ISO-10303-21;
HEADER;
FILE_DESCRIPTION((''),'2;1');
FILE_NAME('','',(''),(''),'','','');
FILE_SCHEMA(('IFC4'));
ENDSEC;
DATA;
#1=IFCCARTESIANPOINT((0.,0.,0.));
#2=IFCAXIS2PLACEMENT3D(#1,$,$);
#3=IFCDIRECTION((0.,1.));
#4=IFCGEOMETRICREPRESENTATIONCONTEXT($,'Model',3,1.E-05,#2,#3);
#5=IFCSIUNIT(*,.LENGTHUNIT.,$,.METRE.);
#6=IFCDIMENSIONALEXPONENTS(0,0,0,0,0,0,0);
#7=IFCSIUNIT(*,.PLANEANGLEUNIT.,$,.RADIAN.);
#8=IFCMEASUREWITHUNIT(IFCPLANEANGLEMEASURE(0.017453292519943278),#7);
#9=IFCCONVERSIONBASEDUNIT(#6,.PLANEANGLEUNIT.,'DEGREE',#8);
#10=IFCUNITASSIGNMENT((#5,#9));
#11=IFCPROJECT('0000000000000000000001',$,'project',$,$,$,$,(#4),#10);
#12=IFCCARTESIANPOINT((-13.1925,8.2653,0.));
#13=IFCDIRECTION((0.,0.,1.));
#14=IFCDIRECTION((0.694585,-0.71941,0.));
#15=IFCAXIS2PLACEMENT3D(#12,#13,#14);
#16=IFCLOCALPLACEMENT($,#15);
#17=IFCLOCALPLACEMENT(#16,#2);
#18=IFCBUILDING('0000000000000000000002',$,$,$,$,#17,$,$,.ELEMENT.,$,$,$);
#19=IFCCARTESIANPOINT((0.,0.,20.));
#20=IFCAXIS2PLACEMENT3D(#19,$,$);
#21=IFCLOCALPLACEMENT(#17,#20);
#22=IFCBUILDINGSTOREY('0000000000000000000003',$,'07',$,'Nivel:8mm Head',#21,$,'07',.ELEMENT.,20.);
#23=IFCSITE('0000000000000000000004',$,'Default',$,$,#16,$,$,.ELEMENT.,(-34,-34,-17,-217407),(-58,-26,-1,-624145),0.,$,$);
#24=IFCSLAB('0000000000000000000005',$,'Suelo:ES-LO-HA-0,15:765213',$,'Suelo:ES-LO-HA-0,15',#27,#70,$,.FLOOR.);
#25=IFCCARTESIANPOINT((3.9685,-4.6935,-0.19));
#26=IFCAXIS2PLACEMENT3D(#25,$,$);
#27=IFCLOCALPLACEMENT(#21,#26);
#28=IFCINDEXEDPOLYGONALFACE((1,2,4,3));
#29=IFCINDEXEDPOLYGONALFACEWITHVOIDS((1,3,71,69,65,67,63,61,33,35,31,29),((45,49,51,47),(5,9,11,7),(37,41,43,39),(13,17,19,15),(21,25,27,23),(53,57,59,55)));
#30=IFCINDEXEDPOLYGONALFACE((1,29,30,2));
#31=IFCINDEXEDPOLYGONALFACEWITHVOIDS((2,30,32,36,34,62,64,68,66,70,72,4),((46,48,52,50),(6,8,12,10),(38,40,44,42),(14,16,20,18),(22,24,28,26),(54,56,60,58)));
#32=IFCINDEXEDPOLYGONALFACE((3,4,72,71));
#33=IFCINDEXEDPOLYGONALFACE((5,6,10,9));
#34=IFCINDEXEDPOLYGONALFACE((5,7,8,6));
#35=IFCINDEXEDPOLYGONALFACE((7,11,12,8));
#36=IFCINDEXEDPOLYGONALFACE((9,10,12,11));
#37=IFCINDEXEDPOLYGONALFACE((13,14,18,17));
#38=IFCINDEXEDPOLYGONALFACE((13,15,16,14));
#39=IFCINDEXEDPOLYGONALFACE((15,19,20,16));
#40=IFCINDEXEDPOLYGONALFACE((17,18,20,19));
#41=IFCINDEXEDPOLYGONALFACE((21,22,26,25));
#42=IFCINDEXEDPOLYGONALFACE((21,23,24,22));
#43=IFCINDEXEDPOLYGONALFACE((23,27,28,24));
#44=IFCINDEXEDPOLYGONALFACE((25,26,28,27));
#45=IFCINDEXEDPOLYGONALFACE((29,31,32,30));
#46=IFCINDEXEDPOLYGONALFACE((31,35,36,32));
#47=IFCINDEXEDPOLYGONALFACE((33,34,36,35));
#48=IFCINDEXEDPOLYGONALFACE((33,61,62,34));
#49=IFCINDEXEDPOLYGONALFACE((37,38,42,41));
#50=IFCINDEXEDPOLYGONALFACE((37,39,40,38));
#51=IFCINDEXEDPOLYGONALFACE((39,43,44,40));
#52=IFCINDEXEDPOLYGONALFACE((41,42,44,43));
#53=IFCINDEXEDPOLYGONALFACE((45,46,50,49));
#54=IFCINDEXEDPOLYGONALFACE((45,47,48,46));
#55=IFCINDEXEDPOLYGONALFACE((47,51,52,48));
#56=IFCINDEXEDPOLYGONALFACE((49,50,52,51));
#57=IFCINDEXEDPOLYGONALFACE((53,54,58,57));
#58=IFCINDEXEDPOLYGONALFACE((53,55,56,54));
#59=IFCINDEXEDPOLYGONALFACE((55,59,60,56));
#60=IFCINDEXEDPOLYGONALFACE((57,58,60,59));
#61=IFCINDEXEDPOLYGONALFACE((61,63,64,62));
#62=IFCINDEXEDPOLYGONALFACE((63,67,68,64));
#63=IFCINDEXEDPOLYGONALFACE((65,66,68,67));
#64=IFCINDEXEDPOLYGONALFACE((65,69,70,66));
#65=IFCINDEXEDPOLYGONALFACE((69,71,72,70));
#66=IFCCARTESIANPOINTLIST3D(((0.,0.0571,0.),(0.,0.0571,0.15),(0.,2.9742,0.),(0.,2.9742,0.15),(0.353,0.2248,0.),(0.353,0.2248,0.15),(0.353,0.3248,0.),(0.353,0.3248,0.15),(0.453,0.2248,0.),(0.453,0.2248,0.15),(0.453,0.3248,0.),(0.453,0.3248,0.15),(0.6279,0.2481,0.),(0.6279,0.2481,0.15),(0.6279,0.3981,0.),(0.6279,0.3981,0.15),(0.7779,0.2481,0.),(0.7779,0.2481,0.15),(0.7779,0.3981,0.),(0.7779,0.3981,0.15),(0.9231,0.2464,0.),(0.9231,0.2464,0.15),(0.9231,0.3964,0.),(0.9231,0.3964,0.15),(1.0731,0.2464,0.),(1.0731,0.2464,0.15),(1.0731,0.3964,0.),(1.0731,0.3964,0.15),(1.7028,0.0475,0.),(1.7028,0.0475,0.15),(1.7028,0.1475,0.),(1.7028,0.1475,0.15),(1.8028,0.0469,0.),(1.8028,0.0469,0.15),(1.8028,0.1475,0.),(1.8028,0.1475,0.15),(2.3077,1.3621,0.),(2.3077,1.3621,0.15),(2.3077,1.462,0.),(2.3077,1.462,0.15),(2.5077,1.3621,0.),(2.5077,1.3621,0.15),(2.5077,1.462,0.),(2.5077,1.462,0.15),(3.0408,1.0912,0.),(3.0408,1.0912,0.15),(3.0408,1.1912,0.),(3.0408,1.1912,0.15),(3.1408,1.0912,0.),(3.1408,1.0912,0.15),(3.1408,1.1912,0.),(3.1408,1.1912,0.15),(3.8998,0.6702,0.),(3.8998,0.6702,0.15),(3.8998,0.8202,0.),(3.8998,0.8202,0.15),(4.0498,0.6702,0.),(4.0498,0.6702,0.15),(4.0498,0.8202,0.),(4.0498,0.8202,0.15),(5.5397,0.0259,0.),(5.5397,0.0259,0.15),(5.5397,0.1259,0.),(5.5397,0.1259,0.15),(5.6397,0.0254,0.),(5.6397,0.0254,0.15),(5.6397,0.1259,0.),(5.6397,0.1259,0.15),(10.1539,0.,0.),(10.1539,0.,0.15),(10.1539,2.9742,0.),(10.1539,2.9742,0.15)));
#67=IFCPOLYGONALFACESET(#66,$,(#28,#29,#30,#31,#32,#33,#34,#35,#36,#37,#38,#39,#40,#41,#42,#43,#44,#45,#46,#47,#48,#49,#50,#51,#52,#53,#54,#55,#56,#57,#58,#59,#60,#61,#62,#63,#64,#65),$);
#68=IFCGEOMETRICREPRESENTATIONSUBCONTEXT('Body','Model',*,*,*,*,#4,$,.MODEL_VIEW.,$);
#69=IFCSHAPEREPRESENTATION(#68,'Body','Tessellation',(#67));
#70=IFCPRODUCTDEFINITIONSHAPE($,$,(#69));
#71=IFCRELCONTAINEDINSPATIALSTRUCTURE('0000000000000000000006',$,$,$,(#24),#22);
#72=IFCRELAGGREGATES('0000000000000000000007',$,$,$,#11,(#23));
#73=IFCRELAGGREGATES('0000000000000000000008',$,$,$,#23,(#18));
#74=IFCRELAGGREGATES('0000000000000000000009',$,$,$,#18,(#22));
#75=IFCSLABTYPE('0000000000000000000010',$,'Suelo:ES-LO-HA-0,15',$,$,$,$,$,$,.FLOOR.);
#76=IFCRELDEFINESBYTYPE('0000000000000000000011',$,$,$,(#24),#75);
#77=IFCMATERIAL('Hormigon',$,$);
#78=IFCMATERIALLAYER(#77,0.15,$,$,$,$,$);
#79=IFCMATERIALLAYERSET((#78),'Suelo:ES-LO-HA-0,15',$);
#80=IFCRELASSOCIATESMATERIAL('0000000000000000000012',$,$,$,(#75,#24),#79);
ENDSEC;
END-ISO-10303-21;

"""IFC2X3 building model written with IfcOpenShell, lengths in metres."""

from ifc_helpers import new_model, entity, si_unit, converted_unit, direction, frame, frame_2d, origin, origin_2d_with_axis, place, context, subcontext, project, spatial, polyline, rectangle, outline, extrude, material, layer, layer_set, layer_usage, type_object, element, save


model = new_model("IFC2X3")

# Units and contexts
model_context = context("Model", 3, precision=1e-05, world=origin(), true_north=direction((0.0, 1.0)))
body_context = subcontext(model_context, "Body", "Model", "MODEL_VIEW")
ifc_project = project(units=[si_unit("LENGTHUNIT", "METRE"), converted_unit("PLANEANGLEUNIT", "DEGREE", entity("IfcPlaneAngleMeasure", 0.017453292519943278), si_unit("PLANEANGLEUNIT", "RADIAN"), dimensions=[0, 0, 0, 0, 0, 0, 0])], contexts=[model_context])

# Site, building, storey
site_placement = place(None, frame((-13.1925, 8.2653, 0.0), z_axis=(0.0, 0.0, 1.0), x_axis=(0.694585, -0.71941, 0.0)))
site = spatial("IfcSite", under=ifc_project, at=site_placement, Name="Default", CompositionType="ELEMENT", RefLatitude=(-34, -34, -17, -217407), RefLongitude=(-58, -26, -1, -624145), RefElevation=0.0)
building_placement = place(site_placement, origin())
building = spatial("IfcBuilding", under=site, at=building_placement, CompositionType="ELEMENT")
storey_placement = place(building_placement, frame((0.0, 0.0, 20.0)))
storey = spatial("IfcBuildingStorey", under=building, at=storey_placement, Name="07", ObjectType="Nivel:8mm Head", LongName="07", CompositionType="ELEMENT", Elevation=20.0)

# Slab, openings
ifc_material_1 = material(Name="Hormigon")
ifc_layer_1 = layer(ifc_material_1, 0.15)
ifc_layer_set_1 = layer_set([ifc_layer_1], Name="Suelo:ES-LO-HA-0,15")
slab_type = type_object("IfcSlabType", Name="Suelo:ES-LO-HA-0,15", PredefinedType="FLOOR", material=ifc_layer_set_1)
ifc_layer_usage_1 = layer_usage(ifc_layer_set_1, "AXIS3", "POSITIVE", 0.0)
slab_1_placement = place(storey_placement, frame((3.9685, -4.6935, -0.19)))
slab_1 = element("IfcSlab", 1, at=slab_1_placement, inside=storey, type_object=slab_type, material=ifc_layer_usage_1, Name="Suelo:ES-LO-HA-0,15:765213", ObjectType="Suelo:ES-LO-HA-0,15", PredefinedType="FLOOR", context=body_context, shape_type="SweptSolid", body=[
    extrude(outline(polyline([(-5.077, 1.4871), (-5.077, -1.4871), (-0.5627, -1.4617), (-0.5627, -1.3612), (-0.4627, -1.3612), (-0.4627, -1.4612), (3.2742, -1.4402), (3.2742, -1.3396), (3.3742, -1.3396), (3.3742, -1.4396), (5.077, -1.43), (5.077, 1.4871), (-5.077, 1.4871)])), frame((5.077, 1.4871, 0.15), z_axis=(0.0, 0.0, -1.0), x_axis=(-1.0, 0.0, 0.0)), (0.0, 0.0, 1.0), 0.15),
])
opening_1_placement = place(slab_1_placement, origin())
element("IfcOpeningElement", 2, at=opening_1_placement, cuts=slab_1, ObjectType="Opening", context=body_context, shape_type="SweptSolid", body=[
    extrude(rectangle(XDim=0.1, YDim=0.2, at=origin_2d_with_axis()), frame((2.4077, 1.412, 0.15), z_axis=(0.0, 0.0, -1.0), x_axis=(0.0, -1.0, 0.0)), (0.0, 0.0, 1.0), 0.15),
])
opening_2_placement = place(slab_1_placement, origin())
element("IfcOpeningElement", 3, at=opening_2_placement, cuts=slab_1, ObjectType="Opening", context=body_context, shape_type="SweptSolid", body=[
    extrude(rectangle(XDim=0.1, YDim=0.1, at=frame_2d((0.0, 0.0), x_axis=(1.0, 0.0))), frame((3.0908, 1.1412, 0.15), z_axis=(0.0, 0.0, -1.0), x_axis=(0.0, -1.0, 0.0)), (0.0, 0.0, 1.0), 0.15),
])
opening_3_placement = place(slab_1_placement, origin())
element("IfcOpeningElement", 4, at=opening_3_placement, cuts=slab_1, ObjectType="Opening", context=body_context, shape_type="SweptSolid", body=[
    extrude(rectangle(XDim=0.15, YDim=0.15, at=frame_2d((0.0, 0.0), x_axis=(1.0, 0.0))), frame((3.9748, 0.7452, 0.15), z_axis=(0.0, 0.0, -1.0), x_axis=(0.0, -1.0, 0.0)), (0.0, 0.0, 1.0), 0.15),
])
opening_4_placement = place(slab_1_placement, origin())
element("IfcOpeningElement", 5, at=opening_4_placement, cuts=slab_1, ObjectType="Opening", context=body_context, shape_type="SweptSolid", body=[
    extrude(rectangle(XDim=0.15, YDim=0.15, at=frame_2d((0.0, 0.0), x_axis=(1.0, 0.0))), frame((0.9981, 0.3214, 0.15), z_axis=(0.0, 0.0, -1.0), x_axis=(0.0, -1.0, 0.0)), (0.0, 0.0, 1.0), 0.15),
])
opening_5_placement = place(slab_1_placement, origin())
element("IfcOpeningElement", 6, at=opening_5_placement, cuts=slab_1, ObjectType="Opening", context=body_context, shape_type="SweptSolid", body=[
    extrude(rectangle(XDim=0.15, YDim=0.15, at=frame_2d((0.0, 0.0), x_axis=(1.0, 0.0))), frame((0.7029, 0.3231, 0.15), z_axis=(0.0, 0.0, 1.0), x_axis=(0.0, -1.0, 0.0)), (0.0, 0.0, -1.0), 0.15),
])
opening_6_placement = place(slab_1_placement, origin())
element("IfcOpeningElement", 7, at=opening_6_placement, cuts=slab_1, ObjectType="Opening", context=body_context, shape_type="SweptSolid", body=[
    extrude(rectangle(XDim=0.1, YDim=0.1, at=frame_2d((0.0, 0.0), x_axis=(1.0, 0.0))), frame((0.403, 0.2748, 0.15), z_axis=(0.0, 0.0, -1.0), x_axis=(0.0, -1.0, 0.0)), (0.0, 0.0, 1.0), 0.15),
])

save(model, "model.ifc")
